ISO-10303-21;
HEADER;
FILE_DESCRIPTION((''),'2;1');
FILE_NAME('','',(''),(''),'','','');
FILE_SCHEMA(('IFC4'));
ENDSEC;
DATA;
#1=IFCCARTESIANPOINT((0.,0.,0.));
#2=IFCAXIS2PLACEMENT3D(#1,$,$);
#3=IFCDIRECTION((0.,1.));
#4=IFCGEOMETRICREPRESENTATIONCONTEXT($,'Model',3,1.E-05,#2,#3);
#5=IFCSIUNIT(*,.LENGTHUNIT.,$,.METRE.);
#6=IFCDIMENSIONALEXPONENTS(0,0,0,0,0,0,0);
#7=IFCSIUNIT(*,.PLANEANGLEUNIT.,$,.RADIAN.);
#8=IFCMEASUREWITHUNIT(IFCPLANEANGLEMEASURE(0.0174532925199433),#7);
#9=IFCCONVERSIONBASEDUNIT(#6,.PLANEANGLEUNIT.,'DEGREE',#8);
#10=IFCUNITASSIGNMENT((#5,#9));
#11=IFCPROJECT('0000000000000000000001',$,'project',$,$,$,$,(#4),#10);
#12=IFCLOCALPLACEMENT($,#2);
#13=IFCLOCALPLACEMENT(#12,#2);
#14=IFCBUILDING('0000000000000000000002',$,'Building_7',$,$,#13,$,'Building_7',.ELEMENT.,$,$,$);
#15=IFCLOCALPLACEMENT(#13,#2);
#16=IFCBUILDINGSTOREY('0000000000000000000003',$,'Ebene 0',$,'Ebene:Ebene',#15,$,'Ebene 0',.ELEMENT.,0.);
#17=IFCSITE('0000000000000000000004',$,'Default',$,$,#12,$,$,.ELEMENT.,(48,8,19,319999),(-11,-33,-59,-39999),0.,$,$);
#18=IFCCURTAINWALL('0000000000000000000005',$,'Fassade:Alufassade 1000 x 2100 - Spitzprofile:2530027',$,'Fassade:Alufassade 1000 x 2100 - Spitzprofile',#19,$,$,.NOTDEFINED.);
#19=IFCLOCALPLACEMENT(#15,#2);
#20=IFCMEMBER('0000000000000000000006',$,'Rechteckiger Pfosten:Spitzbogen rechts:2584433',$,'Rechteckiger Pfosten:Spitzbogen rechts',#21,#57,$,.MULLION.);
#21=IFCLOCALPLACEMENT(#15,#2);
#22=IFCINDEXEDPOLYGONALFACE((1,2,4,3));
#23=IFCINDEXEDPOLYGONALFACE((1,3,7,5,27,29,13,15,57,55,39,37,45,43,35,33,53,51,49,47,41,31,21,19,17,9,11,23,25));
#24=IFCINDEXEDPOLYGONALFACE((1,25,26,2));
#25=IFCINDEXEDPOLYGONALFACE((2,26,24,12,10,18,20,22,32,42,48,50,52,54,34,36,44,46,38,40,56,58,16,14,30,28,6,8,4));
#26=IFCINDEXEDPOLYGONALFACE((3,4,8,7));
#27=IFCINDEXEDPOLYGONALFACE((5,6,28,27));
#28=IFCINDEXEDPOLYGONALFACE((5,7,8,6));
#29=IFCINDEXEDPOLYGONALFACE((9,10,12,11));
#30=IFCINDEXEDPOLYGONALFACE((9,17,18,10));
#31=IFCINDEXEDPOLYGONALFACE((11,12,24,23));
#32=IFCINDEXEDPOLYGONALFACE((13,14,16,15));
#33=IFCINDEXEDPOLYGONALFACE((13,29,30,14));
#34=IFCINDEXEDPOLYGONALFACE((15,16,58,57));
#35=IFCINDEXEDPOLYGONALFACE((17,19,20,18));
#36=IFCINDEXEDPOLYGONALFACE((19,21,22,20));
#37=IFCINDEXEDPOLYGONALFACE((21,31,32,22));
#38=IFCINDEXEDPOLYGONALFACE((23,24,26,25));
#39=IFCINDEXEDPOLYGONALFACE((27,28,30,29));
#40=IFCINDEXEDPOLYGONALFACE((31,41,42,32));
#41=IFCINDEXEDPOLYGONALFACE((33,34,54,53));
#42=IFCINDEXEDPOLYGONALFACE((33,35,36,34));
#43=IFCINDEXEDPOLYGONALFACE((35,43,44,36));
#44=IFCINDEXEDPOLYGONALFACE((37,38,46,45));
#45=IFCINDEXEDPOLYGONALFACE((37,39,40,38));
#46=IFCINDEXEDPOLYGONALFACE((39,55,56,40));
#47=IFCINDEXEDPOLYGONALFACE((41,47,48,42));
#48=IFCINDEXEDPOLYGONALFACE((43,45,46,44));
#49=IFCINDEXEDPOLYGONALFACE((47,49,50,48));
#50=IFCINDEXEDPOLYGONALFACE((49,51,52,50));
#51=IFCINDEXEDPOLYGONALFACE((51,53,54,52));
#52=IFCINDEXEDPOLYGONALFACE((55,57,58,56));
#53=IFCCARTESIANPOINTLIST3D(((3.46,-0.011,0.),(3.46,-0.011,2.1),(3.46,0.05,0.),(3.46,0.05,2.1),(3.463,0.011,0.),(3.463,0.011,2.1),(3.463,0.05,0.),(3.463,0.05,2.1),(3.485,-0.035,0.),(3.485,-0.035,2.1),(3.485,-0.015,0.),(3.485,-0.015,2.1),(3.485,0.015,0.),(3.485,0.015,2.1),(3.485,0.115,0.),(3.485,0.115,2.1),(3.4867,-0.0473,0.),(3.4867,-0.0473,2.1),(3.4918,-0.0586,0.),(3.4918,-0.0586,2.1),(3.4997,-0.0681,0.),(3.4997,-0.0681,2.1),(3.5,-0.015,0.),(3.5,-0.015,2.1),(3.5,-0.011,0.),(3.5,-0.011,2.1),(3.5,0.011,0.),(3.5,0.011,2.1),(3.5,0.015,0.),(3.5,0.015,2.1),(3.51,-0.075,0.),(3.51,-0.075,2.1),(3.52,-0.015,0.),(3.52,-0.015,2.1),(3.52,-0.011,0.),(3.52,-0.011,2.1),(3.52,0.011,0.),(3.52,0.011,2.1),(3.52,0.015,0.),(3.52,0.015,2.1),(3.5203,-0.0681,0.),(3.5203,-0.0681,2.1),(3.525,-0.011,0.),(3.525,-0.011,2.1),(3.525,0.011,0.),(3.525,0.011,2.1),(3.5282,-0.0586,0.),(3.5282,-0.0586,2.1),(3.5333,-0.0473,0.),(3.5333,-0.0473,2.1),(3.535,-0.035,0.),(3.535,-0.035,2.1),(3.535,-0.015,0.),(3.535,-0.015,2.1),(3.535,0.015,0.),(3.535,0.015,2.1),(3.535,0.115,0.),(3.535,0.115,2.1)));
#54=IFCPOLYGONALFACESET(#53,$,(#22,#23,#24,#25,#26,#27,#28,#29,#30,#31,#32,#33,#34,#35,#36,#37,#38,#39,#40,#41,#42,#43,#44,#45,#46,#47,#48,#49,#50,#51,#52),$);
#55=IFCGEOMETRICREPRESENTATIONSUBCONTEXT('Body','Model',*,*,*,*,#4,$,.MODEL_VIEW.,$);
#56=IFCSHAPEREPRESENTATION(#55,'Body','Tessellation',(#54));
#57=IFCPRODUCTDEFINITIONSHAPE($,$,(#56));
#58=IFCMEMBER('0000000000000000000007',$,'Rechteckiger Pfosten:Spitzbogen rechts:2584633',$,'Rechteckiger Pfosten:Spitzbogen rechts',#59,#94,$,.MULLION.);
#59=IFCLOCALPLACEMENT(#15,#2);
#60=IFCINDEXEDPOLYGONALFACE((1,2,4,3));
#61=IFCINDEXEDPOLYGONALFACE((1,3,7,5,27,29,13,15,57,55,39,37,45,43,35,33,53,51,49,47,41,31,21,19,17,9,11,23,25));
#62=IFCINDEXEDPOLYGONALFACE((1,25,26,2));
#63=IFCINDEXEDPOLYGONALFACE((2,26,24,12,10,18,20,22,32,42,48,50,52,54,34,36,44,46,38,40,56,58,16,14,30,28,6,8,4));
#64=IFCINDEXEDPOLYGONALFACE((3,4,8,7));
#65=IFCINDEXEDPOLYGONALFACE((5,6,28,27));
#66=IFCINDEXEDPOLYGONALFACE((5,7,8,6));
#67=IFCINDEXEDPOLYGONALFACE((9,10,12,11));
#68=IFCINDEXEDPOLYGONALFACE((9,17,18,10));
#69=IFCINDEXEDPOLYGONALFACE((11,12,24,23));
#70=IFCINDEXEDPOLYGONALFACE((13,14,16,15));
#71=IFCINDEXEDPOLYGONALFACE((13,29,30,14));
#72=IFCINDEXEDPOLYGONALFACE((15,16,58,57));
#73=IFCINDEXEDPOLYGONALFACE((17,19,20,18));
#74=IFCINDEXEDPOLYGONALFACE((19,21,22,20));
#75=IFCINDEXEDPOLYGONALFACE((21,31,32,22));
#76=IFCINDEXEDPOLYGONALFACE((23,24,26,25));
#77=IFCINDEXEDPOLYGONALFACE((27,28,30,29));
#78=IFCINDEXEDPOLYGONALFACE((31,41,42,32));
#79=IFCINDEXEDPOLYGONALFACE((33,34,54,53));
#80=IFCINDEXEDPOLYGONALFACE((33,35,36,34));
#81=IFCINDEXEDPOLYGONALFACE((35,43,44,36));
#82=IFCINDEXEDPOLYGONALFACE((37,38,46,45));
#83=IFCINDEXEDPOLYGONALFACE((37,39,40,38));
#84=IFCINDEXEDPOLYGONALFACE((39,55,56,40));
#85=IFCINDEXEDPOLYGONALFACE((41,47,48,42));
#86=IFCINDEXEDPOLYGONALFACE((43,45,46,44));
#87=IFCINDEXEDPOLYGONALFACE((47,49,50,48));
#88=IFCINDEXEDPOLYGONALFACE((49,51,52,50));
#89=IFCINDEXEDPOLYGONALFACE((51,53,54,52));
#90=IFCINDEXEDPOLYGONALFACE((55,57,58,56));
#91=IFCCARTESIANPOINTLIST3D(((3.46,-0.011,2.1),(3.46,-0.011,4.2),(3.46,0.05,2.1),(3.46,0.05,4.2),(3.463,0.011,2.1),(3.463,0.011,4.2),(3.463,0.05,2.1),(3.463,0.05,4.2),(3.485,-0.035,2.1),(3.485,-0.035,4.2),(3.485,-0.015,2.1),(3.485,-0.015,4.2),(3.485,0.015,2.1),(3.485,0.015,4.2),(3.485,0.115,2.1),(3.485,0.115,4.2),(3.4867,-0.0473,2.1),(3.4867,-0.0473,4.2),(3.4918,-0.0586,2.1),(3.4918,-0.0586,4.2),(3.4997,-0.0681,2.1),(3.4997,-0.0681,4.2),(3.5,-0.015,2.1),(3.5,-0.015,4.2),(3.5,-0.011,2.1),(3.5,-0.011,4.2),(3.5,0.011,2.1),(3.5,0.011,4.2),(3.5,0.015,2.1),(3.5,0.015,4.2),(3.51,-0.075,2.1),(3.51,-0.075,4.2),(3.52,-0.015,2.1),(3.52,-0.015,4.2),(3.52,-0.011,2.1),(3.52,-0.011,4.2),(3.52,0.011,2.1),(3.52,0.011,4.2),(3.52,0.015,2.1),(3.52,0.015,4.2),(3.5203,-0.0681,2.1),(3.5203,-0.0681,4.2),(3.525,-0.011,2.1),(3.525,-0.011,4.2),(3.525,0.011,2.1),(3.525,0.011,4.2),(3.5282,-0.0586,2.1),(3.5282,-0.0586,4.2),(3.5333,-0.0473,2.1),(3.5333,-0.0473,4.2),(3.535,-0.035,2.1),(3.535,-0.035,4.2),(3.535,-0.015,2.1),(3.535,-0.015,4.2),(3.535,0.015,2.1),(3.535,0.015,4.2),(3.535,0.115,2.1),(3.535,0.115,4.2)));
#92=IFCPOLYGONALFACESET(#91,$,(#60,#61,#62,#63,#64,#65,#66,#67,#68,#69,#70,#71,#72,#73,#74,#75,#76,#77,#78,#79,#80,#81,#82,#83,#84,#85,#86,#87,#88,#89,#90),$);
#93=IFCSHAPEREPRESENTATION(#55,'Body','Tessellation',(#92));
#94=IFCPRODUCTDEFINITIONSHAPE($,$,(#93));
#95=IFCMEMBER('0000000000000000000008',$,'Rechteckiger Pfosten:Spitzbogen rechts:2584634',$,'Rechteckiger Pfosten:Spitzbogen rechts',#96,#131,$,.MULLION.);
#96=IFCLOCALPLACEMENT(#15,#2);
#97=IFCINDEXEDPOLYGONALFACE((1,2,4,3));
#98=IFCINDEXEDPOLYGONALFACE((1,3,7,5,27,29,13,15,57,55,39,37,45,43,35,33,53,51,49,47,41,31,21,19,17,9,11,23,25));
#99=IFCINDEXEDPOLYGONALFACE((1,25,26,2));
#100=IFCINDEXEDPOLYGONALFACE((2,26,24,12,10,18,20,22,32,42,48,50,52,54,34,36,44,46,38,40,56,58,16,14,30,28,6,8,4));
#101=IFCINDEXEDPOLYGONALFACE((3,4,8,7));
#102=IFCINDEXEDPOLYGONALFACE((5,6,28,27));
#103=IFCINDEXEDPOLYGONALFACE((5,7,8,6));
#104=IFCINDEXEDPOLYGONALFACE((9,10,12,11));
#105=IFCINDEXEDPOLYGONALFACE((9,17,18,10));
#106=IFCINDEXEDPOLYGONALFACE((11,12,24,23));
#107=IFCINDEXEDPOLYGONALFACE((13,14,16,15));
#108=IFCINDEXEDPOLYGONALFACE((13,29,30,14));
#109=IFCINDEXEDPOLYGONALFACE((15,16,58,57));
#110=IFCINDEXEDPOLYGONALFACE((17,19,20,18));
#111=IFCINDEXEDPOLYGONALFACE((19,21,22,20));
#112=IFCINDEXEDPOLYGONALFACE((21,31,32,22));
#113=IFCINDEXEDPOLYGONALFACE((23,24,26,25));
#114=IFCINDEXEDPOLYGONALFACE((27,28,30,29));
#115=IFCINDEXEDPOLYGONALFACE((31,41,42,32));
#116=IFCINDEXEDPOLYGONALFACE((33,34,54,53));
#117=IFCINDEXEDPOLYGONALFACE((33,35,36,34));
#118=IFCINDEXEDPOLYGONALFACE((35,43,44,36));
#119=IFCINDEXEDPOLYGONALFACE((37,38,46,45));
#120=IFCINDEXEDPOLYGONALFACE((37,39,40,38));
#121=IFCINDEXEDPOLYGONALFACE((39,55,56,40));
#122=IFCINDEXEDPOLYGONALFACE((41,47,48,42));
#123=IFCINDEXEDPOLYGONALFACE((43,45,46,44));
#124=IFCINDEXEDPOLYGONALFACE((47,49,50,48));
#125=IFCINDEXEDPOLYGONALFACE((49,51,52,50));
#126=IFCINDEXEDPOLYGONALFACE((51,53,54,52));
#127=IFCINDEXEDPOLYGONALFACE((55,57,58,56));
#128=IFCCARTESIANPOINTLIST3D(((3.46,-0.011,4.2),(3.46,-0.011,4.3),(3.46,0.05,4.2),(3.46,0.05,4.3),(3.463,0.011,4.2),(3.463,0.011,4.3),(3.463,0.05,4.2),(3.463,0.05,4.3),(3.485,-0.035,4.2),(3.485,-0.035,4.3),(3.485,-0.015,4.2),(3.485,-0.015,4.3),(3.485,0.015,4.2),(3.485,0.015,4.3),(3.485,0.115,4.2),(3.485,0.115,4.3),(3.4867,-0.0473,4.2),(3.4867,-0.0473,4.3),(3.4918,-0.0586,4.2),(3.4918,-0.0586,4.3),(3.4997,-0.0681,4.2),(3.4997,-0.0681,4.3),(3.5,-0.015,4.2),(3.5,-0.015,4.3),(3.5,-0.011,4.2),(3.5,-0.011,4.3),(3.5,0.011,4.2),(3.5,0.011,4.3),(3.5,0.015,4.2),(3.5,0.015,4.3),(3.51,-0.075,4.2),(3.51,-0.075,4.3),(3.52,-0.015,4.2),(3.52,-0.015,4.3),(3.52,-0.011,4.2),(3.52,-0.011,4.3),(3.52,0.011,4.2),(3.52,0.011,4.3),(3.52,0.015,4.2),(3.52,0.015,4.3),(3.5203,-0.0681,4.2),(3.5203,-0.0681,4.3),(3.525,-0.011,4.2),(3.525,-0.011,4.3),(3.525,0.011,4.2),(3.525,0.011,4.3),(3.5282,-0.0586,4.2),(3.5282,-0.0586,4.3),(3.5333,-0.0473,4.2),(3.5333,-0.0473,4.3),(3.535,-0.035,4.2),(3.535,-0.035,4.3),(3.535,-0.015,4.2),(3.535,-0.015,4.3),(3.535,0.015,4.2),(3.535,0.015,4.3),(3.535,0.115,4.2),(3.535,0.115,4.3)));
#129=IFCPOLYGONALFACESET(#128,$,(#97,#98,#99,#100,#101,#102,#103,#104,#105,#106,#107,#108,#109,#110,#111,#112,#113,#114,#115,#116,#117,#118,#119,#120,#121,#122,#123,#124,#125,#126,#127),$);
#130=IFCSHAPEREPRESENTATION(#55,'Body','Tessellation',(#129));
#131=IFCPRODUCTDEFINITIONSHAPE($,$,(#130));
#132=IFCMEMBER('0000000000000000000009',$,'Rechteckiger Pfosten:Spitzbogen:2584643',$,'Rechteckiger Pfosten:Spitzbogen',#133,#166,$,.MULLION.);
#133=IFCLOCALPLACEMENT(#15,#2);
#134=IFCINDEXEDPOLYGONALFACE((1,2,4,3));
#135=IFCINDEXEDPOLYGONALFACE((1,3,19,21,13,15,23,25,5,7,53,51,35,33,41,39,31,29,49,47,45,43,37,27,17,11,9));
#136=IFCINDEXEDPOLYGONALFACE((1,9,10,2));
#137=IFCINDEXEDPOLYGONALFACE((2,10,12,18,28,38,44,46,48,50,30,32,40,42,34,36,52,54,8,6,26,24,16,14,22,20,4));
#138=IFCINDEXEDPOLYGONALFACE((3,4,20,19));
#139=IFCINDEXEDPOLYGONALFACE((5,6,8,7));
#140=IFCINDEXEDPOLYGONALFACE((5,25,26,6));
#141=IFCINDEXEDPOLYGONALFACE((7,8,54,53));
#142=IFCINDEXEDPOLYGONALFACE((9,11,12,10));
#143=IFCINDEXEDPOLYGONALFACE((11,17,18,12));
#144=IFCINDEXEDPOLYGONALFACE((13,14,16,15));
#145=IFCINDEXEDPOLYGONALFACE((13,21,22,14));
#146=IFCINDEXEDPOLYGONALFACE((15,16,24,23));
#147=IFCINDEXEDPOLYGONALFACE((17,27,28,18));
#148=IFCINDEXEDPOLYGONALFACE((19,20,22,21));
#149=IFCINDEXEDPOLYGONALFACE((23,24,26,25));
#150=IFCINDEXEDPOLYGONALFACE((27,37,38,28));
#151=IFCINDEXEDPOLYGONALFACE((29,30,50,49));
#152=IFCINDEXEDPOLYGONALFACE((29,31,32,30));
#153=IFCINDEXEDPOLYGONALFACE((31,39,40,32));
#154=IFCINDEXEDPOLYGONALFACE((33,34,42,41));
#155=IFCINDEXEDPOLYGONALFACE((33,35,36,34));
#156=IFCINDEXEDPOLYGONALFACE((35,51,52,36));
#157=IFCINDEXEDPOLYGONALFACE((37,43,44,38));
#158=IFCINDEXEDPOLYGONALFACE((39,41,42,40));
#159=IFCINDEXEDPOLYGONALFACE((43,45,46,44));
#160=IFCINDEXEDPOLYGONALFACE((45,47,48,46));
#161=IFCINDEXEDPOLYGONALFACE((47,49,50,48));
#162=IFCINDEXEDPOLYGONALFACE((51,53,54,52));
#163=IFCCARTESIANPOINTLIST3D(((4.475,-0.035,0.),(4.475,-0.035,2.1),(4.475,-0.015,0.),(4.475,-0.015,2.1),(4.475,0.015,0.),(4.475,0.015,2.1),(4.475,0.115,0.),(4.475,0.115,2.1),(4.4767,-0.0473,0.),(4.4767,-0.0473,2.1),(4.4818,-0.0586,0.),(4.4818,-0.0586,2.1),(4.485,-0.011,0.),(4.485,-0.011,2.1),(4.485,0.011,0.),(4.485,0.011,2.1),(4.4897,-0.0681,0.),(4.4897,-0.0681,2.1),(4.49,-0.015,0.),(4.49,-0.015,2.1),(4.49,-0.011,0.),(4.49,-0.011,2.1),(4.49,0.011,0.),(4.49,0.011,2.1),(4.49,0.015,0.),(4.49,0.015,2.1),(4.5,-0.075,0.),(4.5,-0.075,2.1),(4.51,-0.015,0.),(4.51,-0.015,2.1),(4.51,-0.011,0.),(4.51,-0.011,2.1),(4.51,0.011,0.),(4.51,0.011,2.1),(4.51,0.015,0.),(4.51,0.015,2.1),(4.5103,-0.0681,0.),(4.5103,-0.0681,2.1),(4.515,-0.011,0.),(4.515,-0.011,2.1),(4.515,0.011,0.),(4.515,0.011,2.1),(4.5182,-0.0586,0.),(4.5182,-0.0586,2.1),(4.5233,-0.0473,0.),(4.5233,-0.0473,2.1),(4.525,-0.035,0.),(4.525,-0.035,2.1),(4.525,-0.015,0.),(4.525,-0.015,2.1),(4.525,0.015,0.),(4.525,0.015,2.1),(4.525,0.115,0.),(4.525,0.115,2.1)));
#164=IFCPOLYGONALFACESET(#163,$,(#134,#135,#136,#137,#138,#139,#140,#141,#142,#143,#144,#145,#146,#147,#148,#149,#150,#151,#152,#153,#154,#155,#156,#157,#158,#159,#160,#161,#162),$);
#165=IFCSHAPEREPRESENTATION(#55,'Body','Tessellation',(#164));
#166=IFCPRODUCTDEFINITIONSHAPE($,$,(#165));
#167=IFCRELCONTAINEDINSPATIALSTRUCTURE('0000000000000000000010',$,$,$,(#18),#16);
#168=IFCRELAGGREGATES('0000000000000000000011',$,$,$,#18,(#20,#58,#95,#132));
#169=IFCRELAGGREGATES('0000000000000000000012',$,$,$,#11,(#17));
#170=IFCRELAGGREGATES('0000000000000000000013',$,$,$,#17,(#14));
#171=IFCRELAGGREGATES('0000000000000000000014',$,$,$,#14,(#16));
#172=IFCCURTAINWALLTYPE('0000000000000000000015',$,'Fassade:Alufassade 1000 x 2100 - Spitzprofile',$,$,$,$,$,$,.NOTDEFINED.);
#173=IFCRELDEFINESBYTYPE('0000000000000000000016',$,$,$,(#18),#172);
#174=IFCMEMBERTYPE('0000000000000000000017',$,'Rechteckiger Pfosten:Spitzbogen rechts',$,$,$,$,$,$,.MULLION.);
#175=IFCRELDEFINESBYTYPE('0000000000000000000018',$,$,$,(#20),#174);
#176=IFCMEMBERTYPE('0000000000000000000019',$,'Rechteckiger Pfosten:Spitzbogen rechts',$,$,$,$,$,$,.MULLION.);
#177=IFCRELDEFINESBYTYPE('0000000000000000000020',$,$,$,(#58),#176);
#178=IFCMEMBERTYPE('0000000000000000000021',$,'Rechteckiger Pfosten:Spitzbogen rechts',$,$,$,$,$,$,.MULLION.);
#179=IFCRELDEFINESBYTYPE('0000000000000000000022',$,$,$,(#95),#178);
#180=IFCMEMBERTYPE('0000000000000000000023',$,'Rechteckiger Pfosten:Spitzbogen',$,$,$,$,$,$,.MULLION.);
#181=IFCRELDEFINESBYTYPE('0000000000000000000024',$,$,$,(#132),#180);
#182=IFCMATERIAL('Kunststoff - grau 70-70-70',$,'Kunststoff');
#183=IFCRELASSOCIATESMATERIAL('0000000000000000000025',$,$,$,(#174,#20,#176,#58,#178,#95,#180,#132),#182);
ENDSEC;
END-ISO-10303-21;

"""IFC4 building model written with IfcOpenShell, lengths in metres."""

from ifc_helpers import new_model, entity, si_unit, converted_unit, direction, frame, origin, place, context, subcontext, project, spatial, line, arc, indexed_curve, outline, extrude, source, transform, mapped, material, type_object, type_shapes, element, aggregate, save


model = new_model("IFC4")

# Units and contexts
model_context = context("Model", 3, precision=1e-05, world=origin(), true_north=direction((0.0, 1.0)))
body_context = subcontext(model_context, "Body", "Model", "MODEL_VIEW")
ifc_project = project(units=[si_unit("LENGTHUNIT", "METRE"), converted_unit("PLANEANGLEUNIT", "DEGREE", entity("IfcPlaneAngleMeasure", 0.0174532925199433), si_unit("PLANEANGLEUNIT", "RADIAN"), dimensions=[0, 0, 0, 0, 0, 0, 0])], contexts=[model_context])

# Site, building, storey
site_placement = place(None, origin())
site = spatial("IfcSite", under=ifc_project, at=site_placement, Name="Default", CompositionType="ELEMENT", RefLatitude=(48, 8, 19, 319999), RefLongitude=(-11, -33, -59, -39999), RefElevation=0.0)
building_placement = place(site_placement, origin())
building = spatial("IfcBuilding", under=site, at=building_placement, Name="Building_7", LongName="Building_7", CompositionType="ELEMENT")
storey_placement = place(building_placement, origin())
storey = spatial("IfcBuildingStorey", under=building, at=storey_placement, Name="Ebene 0", ObjectType="Ebene:Ebene", LongName="Ebene 0", CompositionType="ELEMENT", Elevation=0.0)

# Curtain wall, members
curtain_wall_type = type_object("IfcCurtainWallType", Name="Fassade:Alufassade 1000 x 2100 - Spitzprofile", PredefinedType="NOTDEFINED")
curtain_wall_placement = place(storey_placement, origin())
curtain_wall = element("IfcCurtainWall", 1, at=curtain_wall_placement, inside=storey, type_object=curtain_wall_type, Name="Fassade:Alufassade 1000 x 2100 - Spitzprofile:2530027", ObjectType="Fassade:Alufassade 1000 x 2100 - Spitzprofile", PredefinedType="NOTDEFINED")
ifc_material_1 = material(Name="Kunststoff - grau 70-70-70", Category="Kunststoff")
member_type_1 = type_object("IfcMemberType", Name="Rechteckiger Pfosten:Spitzbogen rechts", PredefinedType="MULLION", material=ifc_material_1)
shared_shape_1 = source(origin(), body_context, "Body", "SweptSolid", [
    extrude(outline(indexed_curve([(-0.107, -0.0321), (-0.007, -0.0321), (-0.007, -0.0171), (-0.003, -0.0171), (-0.003, -0.0221), (0.019, -0.0221), (0.019, -0.0171), (0.023, -0.0171), (0.023, -0.0321), (0.043, -0.0321), (0.0666, -0.0254), (0.083, -0.0071), (0.0666, 0.0111), (0.043, 0.0179), (0.023, 0.0179), (0.023, 0.0029), (0.019, 0.0029), (0.019, 0.0429), (-0.042, 0.0429), (-0.042, 0.0399), (-0.003, 0.0399), (-0.003, 0.0029), (-0.007, 0.0029), (-0.007, 0.0179), (-0.107, 0.0179)], segments=[line(1, 2, 3, 4, 5, 6, 7, 8, 9, 10), arc(10, 11, 12), arc(12, 13, 14), line(14, 15, 16, 17, 18, 19, 20, 21, 22, 23, 24, 25, 1)], self_intersect=False)), frame((-0.0429, 0.008, -2.1), z_axis=(0.0, 0.0, 1.0), x_axis=(0.0, -1.0, 0.0)), (0.0, 0.0, 1.0), 2.1),
])
type_shapes(member_type_1, [shared_shape_1])
member_1_placement = place(curtain_wall_placement, frame((3.46, 0.0, 0.0), z_axis=(0.0, 0.0, -1.0), x_axis=(-1.0, 0.0, 0.0)))
member_1 = element("IfcMember", 2, at=member_1_placement, type_object=member_type_1, material=ifc_material_1, Name="Rechteckiger Pfosten:Spitzbogen rechts:2584433", ObjectType="Rechteckiger Pfosten:Spitzbogen rechts", PredefinedType="MULLION", context=body_context, shape_type="MappedRepresentation", body=[
    mapped(shared_shape_1, transform((0.0, 0.0, 0.0), scale=1.0)),
])
member_type_2 = type_object("IfcMemberType", Name="Rechteckiger Pfosten:Spitzbogen rechts", PredefinedType="MULLION", material=ifc_material_1)
shared_shape_2 = source(origin(), body_context, "Body", "SweptSolid", [
    extrude(outline(indexed_curve([(-0.107, -0.0321), (-0.007, -0.0321), (-0.007, -0.0171), (-0.003, -0.0171), (-0.003, -0.0221), (0.019, -0.0221), (0.019, -0.0171), (0.023, -0.0171), (0.023, -0.0321), (0.043, -0.0321), (0.0666, -0.0254), (0.083, -0.0071), (0.0666, 0.0111), (0.043, 0.0179), (0.023, 0.0179), (0.023, 0.0029), (0.019, 0.0029), (0.019, 0.0429), (-0.042, 0.0429), (-0.042, 0.0399), (-0.003, 0.0399), (-0.003, 0.0029), (-0.007, 0.0029), (-0.007, 0.0179), (-0.107, 0.0179)], segments=[line(1, 2, 3, 4, 5, 6, 7, 8, 9, 10), arc(10, 11, 12), arc(12, 13, 14), line(14, 15, 16, 17, 18, 19, 20, 21, 22, 23, 24, 25, 1)], self_intersect=False)), frame((-0.0429, 0.008, -2.1), z_axis=(0.0, 0.0, 1.0), x_axis=(0.0, -1.0, 0.0)), (0.0, 0.0, 1.0), 2.1),
])
type_shapes(member_type_2, [shared_shape_2])
member_2_placement = place(curtain_wall_placement, frame((3.46, 0.0, 2.1), z_axis=(0.0, 0.0, -1.0), x_axis=(-1.0, 0.0, 0.0)))
member_2 = element("IfcMember", 3, at=member_2_placement, type_object=member_type_2, material=ifc_material_1, Name="Rechteckiger Pfosten:Spitzbogen rechts:2584633", ObjectType="Rechteckiger Pfosten:Spitzbogen rechts", PredefinedType="MULLION", context=body_context, shape_type="MappedRepresentation", body=[
    mapped(shared_shape_2, transform((0.0, 0.0, 0.0), scale=1.0)),
])
member_type_3 = type_object("IfcMemberType", Name="Rechteckiger Pfosten:Spitzbogen rechts", PredefinedType="MULLION", material=ifc_material_1)
shared_shape_3 = source(origin(), body_context, "Body", "SweptSolid", [
    extrude(outline(indexed_curve([(-0.107, -0.0321), (-0.007, -0.0321), (-0.007, -0.0171), (-0.003, -0.0171), (-0.003, -0.0221), (0.019, -0.0221), (0.019, -0.0171), (0.023, -0.0171), (0.023, -0.0321), (0.043, -0.0321), (0.0666, -0.0254), (0.083, -0.0071), (0.0666, 0.0111), (0.043, 0.0179), (0.023, 0.0179), (0.023, 0.0029), (0.019, 0.0029), (0.019, 0.0429), (-0.042, 0.0429), (-0.042, 0.0399), (-0.003, 0.0399), (-0.003, 0.0029), (-0.007, 0.0029), (-0.007, 0.0179), (-0.107, 0.0179)], segments=[line(1, 2, 3, 4, 5, 6, 7, 8, 9, 10), arc(10, 11, 12), arc(12, 13, 14), line(14, 15, 16, 17, 18, 19, 20, 21, 22, 23, 24, 25, 1)], self_intersect=False)), frame((-0.0429, 0.008, -0.1), z_axis=(0.0, 0.0, 1.0), x_axis=(0.0, -1.0, 0.0)), (0.0, 0.0, 1.0), 0.1),
])
type_shapes(member_type_3, [shared_shape_3])
member_3_placement = place(curtain_wall_placement, frame((3.46, 0.0, 4.2), z_axis=(0.0, 0.0, -1.0), x_axis=(-1.0, 0.0, 0.0)))
member_3 = element("IfcMember", 4, at=member_3_placement, type_object=member_type_3, material=ifc_material_1, Name="Rechteckiger Pfosten:Spitzbogen rechts:2584634", ObjectType="Rechteckiger Pfosten:Spitzbogen rechts", PredefinedType="MULLION", context=body_context, shape_type="MappedRepresentation", body=[
    mapped(shared_shape_3, transform((0.0, 0.0, 0.0), scale=1.0)),
])
member_type_4 = type_object("IfcMemberType", Name="Rechteckiger Pfosten:Spitzbogen", PredefinedType="MULLION", material=ifc_material_1)
shared_shape_4 = source(origin(), body_context, "Body", "SweptSolid", [
    extrude(outline(indexed_curve([(-0.111, -0.025), (-0.011, -0.025), (-0.011, -0.01), (-0.007, -0.01), (-0.007, -0.015), (0.015, -0.015), (0.015, -0.01), (0.019, -0.01), (0.019, -0.025), (0.039, -0.025), (0.0626, -0.0182), (0.079, 0.0), (0.0626, 0.0182), (0.039, 0.025), (0.019, 0.025), (0.019, 0.01), (0.015, 0.01), (0.015, 0.015), (-0.007, 0.015), (-0.007, 0.01), (-0.011, 0.01), (-0.011, 0.025), (-0.111, 0.025)], segments=[line(1, 2, 3, 4, 5, 6, 7, 8, 9, 10), arc(10, 11, 12), arc(12, 13, 14), line(14, 15, 16, 17, 18, 19, 20, 21, 22, 23, 1)], self_intersect=False)), frame((0.0, 0.004, -2.1), z_axis=(0.0, 0.0, 1.0), x_axis=(0.0, -1.0, 0.0)), (0.0, 0.0, 1.0), 2.1),
])
type_shapes(member_type_4, [shared_shape_4])
member_4_placement = place(curtain_wall_placement, frame((4.5, 0.0, 0.0), z_axis=(0.0, 0.0, -1.0), x_axis=(-1.0, 0.0, 0.0)))
member_4 = element("IfcMember", 5, at=member_4_placement, type_object=member_type_4, material=ifc_material_1, Name="Rechteckiger Pfosten:Spitzbogen:2584643", ObjectType="Rechteckiger Pfosten:Spitzbogen", PredefinedType="MULLION", context=body_context, shape_type="MappedRepresentation", body=[
    mapped(shared_shape_4, transform((0.0, 0.0, 0.0), scale=1.0)),
])
aggregate(curtain_wall, [member_1, member_2, member_3, member_4])

save(model, "model.ifc")
